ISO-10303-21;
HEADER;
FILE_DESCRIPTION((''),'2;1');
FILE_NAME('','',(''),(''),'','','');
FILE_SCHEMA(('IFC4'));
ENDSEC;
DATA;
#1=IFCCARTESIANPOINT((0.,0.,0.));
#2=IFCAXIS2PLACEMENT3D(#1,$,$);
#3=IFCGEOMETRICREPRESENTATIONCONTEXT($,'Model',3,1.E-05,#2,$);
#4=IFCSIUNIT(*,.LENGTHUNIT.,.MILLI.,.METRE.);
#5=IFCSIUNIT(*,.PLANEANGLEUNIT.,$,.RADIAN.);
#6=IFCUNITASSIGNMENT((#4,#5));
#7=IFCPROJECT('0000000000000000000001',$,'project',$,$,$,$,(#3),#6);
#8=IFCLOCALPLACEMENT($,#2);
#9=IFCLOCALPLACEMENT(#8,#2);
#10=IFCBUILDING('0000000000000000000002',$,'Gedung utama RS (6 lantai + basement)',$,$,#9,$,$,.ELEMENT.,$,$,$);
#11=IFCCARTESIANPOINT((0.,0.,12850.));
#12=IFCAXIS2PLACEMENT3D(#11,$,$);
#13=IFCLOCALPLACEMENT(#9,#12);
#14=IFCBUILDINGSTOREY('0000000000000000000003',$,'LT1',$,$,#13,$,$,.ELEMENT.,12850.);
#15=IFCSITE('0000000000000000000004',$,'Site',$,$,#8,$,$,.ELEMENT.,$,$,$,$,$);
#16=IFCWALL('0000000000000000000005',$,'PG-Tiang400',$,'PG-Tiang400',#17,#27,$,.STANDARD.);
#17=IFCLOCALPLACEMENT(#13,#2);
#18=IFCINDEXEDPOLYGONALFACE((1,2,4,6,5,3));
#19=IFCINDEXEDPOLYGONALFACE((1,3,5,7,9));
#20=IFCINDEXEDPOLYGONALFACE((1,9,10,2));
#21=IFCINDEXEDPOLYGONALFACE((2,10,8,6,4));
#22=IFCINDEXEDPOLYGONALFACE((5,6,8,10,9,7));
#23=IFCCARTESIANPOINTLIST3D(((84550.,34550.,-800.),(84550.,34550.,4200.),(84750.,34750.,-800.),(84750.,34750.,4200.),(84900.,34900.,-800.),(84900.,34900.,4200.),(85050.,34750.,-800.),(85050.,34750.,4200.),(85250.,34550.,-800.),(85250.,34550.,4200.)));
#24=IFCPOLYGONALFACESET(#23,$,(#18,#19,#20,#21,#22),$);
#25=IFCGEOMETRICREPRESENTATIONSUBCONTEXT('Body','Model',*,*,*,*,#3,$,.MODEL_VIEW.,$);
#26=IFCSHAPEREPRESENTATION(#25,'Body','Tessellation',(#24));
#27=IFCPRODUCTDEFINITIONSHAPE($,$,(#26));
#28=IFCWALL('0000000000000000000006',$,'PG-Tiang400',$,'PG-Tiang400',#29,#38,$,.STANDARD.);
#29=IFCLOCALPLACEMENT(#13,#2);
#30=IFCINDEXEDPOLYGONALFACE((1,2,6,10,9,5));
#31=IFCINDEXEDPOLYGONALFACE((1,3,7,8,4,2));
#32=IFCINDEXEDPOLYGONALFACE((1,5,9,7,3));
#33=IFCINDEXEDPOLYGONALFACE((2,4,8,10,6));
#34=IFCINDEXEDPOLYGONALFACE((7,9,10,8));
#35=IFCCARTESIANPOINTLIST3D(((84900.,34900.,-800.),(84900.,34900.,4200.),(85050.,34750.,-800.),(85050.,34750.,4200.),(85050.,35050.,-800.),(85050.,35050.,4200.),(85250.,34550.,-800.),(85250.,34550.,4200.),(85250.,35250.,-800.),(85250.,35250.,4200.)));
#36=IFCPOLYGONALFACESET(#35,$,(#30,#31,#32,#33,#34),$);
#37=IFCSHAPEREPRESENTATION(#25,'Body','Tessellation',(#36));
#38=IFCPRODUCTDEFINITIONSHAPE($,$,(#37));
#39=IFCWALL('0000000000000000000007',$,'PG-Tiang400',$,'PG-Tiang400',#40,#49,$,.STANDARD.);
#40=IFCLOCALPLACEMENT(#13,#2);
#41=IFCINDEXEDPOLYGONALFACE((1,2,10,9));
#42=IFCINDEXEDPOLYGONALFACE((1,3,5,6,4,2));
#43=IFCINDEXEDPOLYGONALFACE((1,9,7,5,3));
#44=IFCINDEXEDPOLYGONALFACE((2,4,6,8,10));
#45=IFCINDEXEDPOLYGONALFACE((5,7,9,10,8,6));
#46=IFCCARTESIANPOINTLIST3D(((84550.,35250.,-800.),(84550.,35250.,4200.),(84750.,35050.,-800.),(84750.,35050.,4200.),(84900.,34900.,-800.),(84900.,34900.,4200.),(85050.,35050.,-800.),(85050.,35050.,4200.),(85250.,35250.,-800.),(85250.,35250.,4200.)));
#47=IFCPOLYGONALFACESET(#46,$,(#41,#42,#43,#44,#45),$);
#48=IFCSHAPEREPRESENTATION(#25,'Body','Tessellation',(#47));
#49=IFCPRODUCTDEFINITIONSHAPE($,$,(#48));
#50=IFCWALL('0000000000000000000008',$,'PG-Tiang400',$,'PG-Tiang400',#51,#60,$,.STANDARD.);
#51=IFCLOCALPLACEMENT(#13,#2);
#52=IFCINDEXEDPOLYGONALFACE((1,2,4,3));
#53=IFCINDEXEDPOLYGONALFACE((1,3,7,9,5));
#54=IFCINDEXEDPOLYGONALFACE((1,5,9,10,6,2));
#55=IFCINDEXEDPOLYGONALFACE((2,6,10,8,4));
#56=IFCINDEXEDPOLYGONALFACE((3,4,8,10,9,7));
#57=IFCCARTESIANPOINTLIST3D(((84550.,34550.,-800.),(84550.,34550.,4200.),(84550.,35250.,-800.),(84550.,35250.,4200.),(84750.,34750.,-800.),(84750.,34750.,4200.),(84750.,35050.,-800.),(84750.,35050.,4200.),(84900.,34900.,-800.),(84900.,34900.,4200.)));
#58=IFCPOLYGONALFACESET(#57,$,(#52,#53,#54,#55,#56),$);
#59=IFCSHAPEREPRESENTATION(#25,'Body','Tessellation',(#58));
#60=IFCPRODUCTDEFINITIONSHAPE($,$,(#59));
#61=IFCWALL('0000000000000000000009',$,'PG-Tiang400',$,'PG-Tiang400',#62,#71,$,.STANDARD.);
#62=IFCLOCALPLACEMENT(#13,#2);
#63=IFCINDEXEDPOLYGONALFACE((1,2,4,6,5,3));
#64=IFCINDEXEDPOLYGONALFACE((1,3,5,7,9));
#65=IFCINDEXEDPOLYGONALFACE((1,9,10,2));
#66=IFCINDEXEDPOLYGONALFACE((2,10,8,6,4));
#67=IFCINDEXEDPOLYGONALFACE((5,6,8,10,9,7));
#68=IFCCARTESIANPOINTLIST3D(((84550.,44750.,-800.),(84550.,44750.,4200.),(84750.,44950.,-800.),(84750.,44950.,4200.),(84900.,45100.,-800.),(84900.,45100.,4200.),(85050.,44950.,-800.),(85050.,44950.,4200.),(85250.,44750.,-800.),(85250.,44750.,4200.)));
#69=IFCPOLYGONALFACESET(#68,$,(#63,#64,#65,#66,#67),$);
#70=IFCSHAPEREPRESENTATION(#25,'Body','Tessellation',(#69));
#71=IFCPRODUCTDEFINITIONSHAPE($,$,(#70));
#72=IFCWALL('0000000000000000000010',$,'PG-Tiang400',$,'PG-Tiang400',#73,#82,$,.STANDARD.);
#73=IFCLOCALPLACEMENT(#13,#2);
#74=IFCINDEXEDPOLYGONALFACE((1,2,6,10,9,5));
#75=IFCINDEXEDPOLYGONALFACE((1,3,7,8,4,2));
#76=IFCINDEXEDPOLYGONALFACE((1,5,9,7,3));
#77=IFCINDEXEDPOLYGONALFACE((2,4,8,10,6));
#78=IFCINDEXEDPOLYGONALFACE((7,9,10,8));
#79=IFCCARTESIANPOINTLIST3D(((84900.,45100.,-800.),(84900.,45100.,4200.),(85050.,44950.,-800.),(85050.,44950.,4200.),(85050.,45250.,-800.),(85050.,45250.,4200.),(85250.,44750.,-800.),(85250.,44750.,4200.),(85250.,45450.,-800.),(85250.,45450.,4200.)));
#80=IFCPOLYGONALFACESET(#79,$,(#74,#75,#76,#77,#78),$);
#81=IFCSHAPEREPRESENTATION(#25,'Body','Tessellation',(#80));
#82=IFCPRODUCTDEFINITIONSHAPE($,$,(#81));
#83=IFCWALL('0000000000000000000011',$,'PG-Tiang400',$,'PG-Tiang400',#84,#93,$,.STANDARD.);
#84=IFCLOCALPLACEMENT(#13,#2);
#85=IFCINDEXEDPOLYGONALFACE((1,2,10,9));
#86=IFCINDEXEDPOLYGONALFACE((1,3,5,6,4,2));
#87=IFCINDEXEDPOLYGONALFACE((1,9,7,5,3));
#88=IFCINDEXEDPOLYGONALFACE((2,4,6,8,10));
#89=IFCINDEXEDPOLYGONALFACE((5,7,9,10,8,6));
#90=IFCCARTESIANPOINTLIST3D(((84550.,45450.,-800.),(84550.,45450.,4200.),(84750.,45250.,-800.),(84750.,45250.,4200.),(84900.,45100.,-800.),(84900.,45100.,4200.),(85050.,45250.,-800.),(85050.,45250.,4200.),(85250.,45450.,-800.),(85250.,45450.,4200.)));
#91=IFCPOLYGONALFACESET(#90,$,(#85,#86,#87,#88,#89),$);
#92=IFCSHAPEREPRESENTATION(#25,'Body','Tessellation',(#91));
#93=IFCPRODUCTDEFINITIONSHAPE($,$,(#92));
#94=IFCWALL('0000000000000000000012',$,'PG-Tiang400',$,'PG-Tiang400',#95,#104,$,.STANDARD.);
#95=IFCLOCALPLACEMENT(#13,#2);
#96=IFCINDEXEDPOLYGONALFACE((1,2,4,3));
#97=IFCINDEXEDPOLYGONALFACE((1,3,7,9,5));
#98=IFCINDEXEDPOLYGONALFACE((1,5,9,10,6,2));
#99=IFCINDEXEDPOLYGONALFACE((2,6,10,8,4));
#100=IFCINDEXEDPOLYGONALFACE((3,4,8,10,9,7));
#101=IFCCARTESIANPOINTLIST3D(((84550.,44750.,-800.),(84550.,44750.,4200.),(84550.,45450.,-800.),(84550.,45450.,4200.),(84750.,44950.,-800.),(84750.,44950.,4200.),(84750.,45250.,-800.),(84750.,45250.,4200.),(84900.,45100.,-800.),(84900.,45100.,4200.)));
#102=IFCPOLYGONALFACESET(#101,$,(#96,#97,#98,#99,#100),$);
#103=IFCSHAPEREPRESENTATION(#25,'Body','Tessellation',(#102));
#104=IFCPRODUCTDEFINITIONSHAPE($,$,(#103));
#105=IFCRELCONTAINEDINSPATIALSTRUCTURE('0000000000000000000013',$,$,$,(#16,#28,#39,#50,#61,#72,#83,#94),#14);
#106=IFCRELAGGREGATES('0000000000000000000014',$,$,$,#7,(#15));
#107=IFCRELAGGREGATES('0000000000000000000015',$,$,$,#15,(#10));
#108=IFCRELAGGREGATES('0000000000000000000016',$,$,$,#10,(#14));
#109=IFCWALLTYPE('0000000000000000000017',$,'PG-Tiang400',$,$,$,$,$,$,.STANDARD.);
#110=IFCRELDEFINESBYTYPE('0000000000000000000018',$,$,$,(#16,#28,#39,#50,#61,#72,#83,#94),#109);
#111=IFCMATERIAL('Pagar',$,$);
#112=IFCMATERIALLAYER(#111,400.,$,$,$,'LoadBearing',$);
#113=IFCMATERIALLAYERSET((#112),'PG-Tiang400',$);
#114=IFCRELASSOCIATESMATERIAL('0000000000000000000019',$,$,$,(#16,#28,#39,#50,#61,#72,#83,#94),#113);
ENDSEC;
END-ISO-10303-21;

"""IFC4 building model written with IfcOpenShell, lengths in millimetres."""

from ifc_helpers import new_model, si_unit, frame, origin, place, context, subcontext, project, spatial, polyline, outline, extrude, material, layer, layer_set, layer_usage, type_object, element, save


model = new_model("IFC4")

# Units and contexts
model_context = context("Model", 3, precision=1e-05, world=origin())
body_context = subcontext(model_context, "Body", "Model", "MODEL_VIEW")
ifc_project = project(units=[si_unit("LENGTHUNIT", "METRE", prefix="MILLI"), si_unit("PLANEANGLEUNIT", "RADIAN")], contexts=[model_context])

# Site, building, storey
site_placement = place(None, origin())
site = spatial("IfcSite", under=ifc_project, at=site_placement, Name="Site", CompositionType="ELEMENT")
building_placement = place(site_placement, origin())
building = spatial("IfcBuilding", under=site, at=building_placement, Name="Gedung utama RS (6 lantai + basement)", CompositionType="ELEMENT")
storey_placement = place(building_placement, frame((0.0, 0.0, 12850.0)))
storey = spatial("IfcBuildingStorey", under=building, at=storey_placement, Name="LT1", CompositionType="ELEMENT", Elevation=12850.0)

# Walls
ifc_material_1 = material(Name="Pagar")
ifc_layer_1 = layer(ifc_material_1, 400.0, Category="LoadBearing")
ifc_layer_set_1 = layer_set([ifc_layer_1], Name="PG-Tiang400")
ifc_layer_usage_1 = layer_usage(ifc_layer_set_1, "AXIS2", "NEGATIVE", 200.0)
wall_type_1 = type_object("IfcWallType", Name="PG-Tiang400", PredefinedType="STANDARD")
for number, where, z_axis, x_axis, name in (
    (1, (84750.0, 34750.0, -800.0), (0.0, 0.0, 1.0), (1.0, 0.0, 0.0), "PG-Tiang400"),
    (2, (85050.0, 34750.0, -800.0), (0.0, 0.0, 1.0), (0.0, 1.0, 0.0), "PG-Tiang400"),
    (3, (85050.0, 35050.0, -800.0), (0.0, 0.0, 1.0), (-1.0, 0.0, 0.0), "PG-Tiang400"),
    (4, (84750.0, 35050.0, -800.0), (0.0, 0.0, 1.0), (0.0, -1.0, 0.0), "PG-Tiang400"),
    (5, (84750.0, 44950.0, -800.0), (0.0, 0.0, 1.0), (1.0, 0.0, 0.0), "PG-Tiang400"),
    (6, (85050.0, 44950.0, -800.0), (0.0, 0.0, 1.0), (0.0, 1.0, 0.0), "PG-Tiang400"),
    (7, (85050.0, 45250.0, -800.0), (0.0, 0.0, 1.0), (-1.0, 0.0, 0.0), "PG-Tiang400"),
    (8, (84750.0, 45250.0, -800.0), (0.0, 0.0, 1.0), (0.0, -1.0, 0.0), "PG-Tiang400"),
):
    element("IfcWall", number, at=place(storey_placement, frame(where, z_axis=z_axis, x_axis=x_axis)), inside=storey, type_object=wall_type_1, material=ifc_layer_usage_1, Name=name, ObjectType="PG-Tiang400", PredefinedType="STANDARD", context=body_context, shape_type="SweptSolid", body=[
        extrude(outline(polyline([(-200.0, -200.0), (0.0, 0.0), (200.0, 200.0), (100.0, 200.0), (300.0, 0.0), (500.0, -200.0), (-200.0, -200.0)])), origin(), (0.0, 0.0, 1.0), 5000.0),
    ])

save(model, "model.ifc")
